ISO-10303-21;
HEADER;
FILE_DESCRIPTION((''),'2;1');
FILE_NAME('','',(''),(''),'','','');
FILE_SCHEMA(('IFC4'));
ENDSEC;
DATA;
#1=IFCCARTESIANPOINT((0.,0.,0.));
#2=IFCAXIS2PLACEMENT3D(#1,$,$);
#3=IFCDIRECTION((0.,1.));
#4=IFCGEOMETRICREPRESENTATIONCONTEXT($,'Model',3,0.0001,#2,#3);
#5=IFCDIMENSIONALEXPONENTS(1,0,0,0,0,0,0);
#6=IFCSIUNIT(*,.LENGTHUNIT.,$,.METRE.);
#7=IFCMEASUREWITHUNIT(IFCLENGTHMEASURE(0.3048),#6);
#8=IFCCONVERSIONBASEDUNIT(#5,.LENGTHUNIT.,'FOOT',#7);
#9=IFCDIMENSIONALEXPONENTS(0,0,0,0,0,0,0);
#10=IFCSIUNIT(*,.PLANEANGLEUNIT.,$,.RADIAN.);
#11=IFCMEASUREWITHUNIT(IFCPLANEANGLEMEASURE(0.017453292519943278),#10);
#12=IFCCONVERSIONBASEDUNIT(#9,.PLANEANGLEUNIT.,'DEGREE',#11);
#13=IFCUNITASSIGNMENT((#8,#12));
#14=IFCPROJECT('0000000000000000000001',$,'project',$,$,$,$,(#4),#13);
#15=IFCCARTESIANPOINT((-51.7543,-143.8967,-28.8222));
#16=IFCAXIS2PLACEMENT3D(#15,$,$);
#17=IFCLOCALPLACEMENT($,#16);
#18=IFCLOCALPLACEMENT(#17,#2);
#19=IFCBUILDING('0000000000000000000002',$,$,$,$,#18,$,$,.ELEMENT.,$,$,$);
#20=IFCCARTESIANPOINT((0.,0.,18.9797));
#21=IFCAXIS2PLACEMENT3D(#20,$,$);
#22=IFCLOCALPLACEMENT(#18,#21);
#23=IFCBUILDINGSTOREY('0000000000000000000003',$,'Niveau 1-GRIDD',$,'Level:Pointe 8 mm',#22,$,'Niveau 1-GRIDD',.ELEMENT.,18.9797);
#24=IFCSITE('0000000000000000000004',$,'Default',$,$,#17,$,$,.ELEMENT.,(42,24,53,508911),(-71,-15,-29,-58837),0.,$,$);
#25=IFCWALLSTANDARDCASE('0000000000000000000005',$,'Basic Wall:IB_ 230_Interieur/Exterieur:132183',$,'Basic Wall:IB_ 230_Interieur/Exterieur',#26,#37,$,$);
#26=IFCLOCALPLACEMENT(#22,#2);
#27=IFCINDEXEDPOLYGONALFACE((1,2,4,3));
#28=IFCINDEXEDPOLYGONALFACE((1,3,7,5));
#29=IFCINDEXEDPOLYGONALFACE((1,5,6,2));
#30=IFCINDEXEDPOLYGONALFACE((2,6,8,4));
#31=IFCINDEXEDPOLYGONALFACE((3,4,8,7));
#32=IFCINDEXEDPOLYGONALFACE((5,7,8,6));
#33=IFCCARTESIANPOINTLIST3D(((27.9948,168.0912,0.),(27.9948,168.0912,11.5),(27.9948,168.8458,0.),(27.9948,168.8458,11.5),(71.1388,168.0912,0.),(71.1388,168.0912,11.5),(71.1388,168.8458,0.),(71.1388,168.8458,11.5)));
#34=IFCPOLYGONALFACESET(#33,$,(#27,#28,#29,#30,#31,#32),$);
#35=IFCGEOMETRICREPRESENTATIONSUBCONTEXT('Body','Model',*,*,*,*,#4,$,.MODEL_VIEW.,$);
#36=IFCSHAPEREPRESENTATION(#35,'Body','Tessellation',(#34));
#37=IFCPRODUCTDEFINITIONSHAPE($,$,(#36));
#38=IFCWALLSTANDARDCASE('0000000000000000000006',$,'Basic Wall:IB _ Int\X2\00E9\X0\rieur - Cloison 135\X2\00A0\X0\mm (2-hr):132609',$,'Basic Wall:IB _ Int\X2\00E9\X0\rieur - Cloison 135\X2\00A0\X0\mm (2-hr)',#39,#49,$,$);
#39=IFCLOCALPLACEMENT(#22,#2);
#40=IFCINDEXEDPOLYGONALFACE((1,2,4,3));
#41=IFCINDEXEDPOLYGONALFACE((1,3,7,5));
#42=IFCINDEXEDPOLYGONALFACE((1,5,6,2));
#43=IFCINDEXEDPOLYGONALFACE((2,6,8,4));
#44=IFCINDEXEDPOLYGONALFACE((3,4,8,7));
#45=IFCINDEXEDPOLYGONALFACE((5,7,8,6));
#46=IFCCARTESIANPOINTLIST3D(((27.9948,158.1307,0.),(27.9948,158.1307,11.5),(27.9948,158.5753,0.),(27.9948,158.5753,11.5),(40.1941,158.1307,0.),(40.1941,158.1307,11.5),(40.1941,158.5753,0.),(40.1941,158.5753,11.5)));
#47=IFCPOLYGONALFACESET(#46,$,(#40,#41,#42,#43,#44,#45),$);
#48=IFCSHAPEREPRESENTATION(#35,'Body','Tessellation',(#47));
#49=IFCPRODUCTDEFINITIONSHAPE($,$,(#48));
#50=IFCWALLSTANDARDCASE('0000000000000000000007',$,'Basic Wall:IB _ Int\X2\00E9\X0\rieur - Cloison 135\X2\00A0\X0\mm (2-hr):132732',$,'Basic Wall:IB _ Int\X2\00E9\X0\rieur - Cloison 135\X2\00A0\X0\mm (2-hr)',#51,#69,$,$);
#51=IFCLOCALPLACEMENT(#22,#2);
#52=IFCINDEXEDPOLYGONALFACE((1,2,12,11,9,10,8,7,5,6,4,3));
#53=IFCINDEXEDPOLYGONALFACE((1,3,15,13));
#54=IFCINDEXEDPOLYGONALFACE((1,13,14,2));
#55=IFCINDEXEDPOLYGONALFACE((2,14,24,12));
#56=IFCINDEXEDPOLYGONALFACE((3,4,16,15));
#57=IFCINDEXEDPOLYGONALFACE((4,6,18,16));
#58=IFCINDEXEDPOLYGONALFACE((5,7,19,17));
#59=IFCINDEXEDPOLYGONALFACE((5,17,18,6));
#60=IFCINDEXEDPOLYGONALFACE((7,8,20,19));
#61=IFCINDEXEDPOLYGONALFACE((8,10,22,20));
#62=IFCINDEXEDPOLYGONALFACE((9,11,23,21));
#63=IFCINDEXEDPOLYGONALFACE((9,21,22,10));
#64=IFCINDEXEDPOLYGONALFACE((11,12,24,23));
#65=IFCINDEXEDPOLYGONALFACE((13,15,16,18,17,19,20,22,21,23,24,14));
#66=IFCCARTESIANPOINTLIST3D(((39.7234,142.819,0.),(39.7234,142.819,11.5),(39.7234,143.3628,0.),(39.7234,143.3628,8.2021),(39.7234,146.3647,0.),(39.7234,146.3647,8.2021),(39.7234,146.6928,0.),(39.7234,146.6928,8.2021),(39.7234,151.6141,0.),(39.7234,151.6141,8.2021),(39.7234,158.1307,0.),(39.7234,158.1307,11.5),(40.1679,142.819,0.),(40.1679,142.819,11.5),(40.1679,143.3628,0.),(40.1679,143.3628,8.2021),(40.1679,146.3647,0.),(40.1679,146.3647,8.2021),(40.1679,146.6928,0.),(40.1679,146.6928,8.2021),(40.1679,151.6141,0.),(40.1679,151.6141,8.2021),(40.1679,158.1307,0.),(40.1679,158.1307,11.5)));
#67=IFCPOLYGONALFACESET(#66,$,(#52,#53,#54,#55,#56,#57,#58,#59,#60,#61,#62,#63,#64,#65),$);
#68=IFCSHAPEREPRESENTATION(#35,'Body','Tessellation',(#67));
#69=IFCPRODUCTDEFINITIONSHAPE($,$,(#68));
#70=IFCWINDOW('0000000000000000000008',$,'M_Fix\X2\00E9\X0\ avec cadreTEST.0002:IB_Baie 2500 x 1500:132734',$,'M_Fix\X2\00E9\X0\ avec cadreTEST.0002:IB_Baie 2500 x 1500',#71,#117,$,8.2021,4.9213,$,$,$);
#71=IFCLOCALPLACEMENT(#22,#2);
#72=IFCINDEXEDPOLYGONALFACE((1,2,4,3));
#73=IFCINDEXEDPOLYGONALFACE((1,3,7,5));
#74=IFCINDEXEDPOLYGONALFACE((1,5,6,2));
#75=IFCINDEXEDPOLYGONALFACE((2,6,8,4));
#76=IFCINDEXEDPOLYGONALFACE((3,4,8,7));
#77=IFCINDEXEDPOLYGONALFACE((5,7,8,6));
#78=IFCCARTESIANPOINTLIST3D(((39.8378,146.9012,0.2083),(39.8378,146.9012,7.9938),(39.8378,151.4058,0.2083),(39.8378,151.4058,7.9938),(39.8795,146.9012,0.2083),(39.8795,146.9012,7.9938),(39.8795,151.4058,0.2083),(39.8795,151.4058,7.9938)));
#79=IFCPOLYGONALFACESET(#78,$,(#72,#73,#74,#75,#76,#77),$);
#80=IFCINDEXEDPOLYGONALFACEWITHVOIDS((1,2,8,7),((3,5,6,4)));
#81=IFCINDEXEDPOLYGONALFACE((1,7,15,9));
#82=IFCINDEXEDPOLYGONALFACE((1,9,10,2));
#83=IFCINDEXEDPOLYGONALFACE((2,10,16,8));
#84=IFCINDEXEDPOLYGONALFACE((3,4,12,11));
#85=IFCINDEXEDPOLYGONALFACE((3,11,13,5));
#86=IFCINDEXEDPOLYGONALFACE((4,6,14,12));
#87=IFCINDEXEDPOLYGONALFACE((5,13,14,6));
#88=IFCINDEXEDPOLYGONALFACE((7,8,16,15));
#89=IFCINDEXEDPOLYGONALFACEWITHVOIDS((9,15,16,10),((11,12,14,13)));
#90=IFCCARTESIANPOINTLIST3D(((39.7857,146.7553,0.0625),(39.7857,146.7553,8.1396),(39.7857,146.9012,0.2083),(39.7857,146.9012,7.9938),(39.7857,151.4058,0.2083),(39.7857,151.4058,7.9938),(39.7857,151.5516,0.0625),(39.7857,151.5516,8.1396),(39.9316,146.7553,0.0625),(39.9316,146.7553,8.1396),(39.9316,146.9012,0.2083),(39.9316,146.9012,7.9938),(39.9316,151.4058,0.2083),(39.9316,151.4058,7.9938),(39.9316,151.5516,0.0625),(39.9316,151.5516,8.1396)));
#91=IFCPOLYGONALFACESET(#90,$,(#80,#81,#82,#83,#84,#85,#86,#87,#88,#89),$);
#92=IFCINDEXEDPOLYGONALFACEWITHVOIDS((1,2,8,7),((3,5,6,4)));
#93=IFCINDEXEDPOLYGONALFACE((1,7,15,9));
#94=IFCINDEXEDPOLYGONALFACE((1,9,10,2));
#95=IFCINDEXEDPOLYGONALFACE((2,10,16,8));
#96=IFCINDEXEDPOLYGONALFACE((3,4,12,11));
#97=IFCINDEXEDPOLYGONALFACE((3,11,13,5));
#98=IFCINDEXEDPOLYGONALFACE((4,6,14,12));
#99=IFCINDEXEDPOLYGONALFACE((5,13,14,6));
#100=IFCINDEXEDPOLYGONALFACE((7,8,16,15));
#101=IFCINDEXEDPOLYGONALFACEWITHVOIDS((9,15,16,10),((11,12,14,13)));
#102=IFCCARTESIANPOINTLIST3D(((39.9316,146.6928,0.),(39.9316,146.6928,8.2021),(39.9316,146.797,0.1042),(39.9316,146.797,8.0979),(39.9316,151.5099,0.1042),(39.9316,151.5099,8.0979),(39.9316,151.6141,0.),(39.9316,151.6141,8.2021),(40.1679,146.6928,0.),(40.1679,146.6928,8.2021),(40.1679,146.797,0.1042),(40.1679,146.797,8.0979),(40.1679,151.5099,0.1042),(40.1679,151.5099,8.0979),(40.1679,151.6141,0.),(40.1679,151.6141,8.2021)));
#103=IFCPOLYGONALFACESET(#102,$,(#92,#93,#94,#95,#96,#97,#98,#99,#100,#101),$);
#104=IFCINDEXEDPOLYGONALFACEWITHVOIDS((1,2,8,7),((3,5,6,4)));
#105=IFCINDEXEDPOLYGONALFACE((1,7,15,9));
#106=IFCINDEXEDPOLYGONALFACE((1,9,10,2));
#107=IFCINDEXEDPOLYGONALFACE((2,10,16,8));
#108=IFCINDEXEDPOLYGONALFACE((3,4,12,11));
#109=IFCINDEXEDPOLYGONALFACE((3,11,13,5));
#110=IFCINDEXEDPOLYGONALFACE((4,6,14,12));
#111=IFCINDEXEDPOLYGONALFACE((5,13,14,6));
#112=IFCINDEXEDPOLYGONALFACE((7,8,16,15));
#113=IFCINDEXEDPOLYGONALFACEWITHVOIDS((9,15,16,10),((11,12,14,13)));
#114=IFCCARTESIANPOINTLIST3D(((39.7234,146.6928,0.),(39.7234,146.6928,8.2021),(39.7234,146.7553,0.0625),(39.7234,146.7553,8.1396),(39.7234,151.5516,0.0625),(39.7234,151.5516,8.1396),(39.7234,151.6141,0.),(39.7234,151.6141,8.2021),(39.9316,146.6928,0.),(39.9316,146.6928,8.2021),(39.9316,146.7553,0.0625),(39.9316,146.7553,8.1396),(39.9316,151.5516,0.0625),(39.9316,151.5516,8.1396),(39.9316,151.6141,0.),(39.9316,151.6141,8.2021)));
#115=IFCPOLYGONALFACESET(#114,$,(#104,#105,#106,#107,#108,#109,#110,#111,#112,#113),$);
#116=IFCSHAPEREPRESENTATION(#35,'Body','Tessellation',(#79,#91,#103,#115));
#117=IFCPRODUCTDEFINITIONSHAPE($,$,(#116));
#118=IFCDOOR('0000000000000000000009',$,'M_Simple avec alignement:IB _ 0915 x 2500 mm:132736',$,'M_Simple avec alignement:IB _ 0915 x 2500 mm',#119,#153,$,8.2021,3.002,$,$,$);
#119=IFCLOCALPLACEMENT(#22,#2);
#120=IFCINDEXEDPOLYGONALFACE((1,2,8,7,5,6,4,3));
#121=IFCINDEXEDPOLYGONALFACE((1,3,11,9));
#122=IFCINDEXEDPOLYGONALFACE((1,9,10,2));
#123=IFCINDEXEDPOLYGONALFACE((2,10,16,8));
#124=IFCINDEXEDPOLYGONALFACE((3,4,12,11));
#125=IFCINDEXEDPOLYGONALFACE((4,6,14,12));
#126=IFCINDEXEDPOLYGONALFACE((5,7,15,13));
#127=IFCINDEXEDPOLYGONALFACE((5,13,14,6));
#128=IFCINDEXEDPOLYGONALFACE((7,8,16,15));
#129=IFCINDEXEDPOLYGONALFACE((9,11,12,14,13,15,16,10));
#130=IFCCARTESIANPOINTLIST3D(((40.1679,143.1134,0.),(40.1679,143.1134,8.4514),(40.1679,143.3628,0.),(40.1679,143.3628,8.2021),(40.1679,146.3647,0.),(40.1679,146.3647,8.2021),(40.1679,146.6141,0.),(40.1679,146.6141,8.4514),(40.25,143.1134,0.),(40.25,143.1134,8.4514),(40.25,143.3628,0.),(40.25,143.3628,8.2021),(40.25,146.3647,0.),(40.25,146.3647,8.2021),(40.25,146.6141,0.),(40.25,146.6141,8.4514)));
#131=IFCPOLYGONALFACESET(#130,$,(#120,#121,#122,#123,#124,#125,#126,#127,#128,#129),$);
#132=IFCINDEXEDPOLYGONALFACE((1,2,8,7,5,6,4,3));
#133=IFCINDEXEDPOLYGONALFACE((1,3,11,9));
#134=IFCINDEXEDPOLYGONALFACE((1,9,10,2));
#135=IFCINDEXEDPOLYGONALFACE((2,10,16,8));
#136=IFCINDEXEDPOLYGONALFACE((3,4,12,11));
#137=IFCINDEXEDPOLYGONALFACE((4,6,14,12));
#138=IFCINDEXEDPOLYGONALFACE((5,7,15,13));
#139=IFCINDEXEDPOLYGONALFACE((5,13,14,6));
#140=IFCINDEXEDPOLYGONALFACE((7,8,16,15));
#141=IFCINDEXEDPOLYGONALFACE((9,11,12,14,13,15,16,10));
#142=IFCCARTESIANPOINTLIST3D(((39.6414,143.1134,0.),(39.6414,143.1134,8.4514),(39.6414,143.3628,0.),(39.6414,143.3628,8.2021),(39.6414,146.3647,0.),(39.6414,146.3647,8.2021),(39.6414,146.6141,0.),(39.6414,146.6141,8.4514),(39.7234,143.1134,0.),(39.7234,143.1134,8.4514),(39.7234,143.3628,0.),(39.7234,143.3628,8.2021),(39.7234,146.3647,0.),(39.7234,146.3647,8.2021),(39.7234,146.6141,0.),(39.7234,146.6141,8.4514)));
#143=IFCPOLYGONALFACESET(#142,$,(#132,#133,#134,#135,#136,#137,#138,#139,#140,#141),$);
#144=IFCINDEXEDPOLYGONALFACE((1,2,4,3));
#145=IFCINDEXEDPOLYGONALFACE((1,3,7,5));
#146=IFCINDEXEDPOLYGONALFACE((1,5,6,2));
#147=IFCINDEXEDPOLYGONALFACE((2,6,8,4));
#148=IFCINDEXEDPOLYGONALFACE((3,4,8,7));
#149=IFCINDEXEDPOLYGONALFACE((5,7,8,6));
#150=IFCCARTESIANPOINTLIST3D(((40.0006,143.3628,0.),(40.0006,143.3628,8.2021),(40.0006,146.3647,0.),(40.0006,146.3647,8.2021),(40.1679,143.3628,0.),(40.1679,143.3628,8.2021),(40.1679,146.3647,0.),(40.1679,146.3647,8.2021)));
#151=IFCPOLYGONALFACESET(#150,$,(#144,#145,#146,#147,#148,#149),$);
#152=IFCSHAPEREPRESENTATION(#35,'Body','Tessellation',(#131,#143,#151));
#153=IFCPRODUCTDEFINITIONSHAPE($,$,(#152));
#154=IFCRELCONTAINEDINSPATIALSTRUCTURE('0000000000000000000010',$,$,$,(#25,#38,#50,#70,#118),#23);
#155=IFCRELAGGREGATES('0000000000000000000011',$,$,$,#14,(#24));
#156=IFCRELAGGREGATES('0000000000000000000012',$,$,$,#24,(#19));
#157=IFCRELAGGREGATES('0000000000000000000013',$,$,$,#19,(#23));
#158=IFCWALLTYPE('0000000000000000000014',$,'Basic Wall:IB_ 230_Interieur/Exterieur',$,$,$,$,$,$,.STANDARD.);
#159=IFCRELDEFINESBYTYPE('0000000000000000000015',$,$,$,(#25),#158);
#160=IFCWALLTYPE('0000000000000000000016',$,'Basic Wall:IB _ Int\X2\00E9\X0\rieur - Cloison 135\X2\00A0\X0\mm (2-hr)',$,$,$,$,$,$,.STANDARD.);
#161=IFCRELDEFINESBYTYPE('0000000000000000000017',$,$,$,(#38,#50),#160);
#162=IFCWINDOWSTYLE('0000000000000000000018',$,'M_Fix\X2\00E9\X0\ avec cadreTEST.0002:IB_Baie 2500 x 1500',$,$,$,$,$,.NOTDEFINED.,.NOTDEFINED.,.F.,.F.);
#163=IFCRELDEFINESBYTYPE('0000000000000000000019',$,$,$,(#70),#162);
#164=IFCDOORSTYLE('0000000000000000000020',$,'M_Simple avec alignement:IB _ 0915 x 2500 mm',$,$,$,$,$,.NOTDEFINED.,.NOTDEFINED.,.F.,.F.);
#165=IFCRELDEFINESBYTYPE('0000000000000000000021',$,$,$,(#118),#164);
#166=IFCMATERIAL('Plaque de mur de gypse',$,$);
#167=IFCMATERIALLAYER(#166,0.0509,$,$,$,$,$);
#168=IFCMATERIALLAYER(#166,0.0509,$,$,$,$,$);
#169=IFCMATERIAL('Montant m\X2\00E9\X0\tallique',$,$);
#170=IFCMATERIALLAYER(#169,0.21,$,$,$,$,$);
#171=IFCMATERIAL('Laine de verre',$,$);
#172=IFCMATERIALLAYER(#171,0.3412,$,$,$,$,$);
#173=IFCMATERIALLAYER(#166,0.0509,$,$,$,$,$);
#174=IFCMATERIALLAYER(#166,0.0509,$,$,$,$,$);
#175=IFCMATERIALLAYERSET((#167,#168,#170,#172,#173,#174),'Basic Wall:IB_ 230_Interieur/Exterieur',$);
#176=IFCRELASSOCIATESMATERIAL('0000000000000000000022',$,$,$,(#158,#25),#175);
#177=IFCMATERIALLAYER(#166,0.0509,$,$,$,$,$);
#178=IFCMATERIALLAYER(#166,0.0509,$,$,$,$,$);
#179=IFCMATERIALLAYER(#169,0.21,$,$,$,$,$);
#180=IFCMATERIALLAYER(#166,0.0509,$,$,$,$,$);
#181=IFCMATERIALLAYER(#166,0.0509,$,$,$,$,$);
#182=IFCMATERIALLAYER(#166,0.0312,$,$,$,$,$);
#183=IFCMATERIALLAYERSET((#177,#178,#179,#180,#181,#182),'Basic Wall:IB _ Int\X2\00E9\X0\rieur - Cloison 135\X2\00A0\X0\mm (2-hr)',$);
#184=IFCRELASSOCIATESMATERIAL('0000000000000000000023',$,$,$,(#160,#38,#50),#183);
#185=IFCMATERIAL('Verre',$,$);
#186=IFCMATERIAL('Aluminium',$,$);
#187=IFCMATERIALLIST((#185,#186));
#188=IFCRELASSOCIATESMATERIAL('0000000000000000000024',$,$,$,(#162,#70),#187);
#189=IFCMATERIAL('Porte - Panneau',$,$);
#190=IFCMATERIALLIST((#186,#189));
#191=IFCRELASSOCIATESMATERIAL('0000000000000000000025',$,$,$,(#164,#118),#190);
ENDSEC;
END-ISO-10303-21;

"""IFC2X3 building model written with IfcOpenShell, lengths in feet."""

from ifc_helpers import new_model, entity, si_unit, converted_unit, direction, frame, frame_2d, origin, place, context, subcontext, project, spatial, polyline, rectangle, outline, extrude, source, transform, mapped, material, material_list, layer, layer_set, layer_usage, type_object, type_shapes, element, fill, save


model = new_model("IFC2X3")

# Units and contexts
model_context = context("Model", 3, precision=0.0001, world=origin(), true_north=direction((0.0, 1.0)))
body_context = subcontext(model_context, "Body", "Model", "MODEL_VIEW")
ifc_project = project(units=[converted_unit("LENGTHUNIT", "FOOT", entity("IfcLengthMeasure", 0.3048), si_unit("LENGTHUNIT", "METRE"), dimensions=[1, 0, 0, 0, 0, 0, 0]), converted_unit("PLANEANGLEUNIT", "DEGREE", entity("IfcPlaneAngleMeasure", 0.017453292519943278), si_unit("PLANEANGLEUNIT", "RADIAN"), dimensions=[0, 0, 0, 0, 0, 0, 0])], contexts=[model_context])

# Site, building, storey
site_placement = place(None, frame((-51.7543, -143.8967, -28.8222)))
site = spatial("IfcSite", under=ifc_project, at=site_placement, Name="Default", CompositionType="ELEMENT", RefLatitude=(42, 24, 53, 508911), RefLongitude=(-71, -15, -29, -58837), RefElevation=0.0)
building_placement = place(site_placement, origin())
building = spatial("IfcBuilding", under=site, at=building_placement, CompositionType="ELEMENT")
storey_placement = place(building_placement, frame((0.0, 0.0, 18.9797)))
storey = spatial("IfcBuildingStorey", under=building, at=storey_placement, Name="Niveau 1-GRIDD", ObjectType="Level:Pointe 8 mm", LongName="Niveau 1-GRIDD", CompositionType="ELEMENT", Elevation=18.9797)

# Walls
ifc_material_1 = material(Name="Plaque de mur de gypse")
ifc_layer_1 = layer(ifc_material_1, 0.0509)
ifc_layer_2 = layer(ifc_material_1, 0.0509)
ifc_material_2 = material(Name="Montant métallique")
ifc_layer_3 = layer(ifc_material_2, 0.21)
ifc_material_3 = material(Name="Laine de verre")
ifc_layer_4 = layer(ifc_material_3, 0.3412)
ifc_layer_5 = layer(ifc_material_1, 0.0509)
ifc_layer_6 = layer(ifc_material_1, 0.0509)
ifc_layer_set_1 = layer_set([ifc_layer_1, ifc_layer_2, ifc_layer_3, ifc_layer_4, ifc_layer_5, ifc_layer_6], Name="Basic Wall:IB_ 230_Interieur/Exterieur")
ifc_layer_usage_1 = layer_usage(ifc_layer_set_1, "AXIS2", "NEGATIVE", 0.3773)
wall_type_1 = type_object("IfcWallType", Name="Basic Wall:IB_ 230_Interieur/Exterieur", PredefinedType="STANDARD", material=ifc_layer_set_1)
wall_1_placement = place(storey_placement, frame((27.9948, 168.4685, 0.0)))
element("IfcWallStandardCase", 1, at=wall_1_placement, inside=storey, type_object=wall_type_1, material=ifc_layer_usage_1, Name="Basic Wall:IB_ 230_Interieur/Exterieur:132183", ObjectType="Basic Wall:IB_ 230_Interieur/Exterieur", context=body_context, shape_type="SweptSolid", body=[
    extrude(rectangle(XDim=43.144, YDim=0.7546, at=frame_2d((21.572, 0.0), x_axis=(-1.0, 0.0))), origin(), (0.0, 0.0, 1.0), 11.5),
])
ifc_layer_7 = layer(ifc_material_1, 0.0509)
ifc_layer_8 = layer(ifc_material_1, 0.0509)
ifc_layer_9 = layer(ifc_material_2, 0.21)
ifc_layer_10 = layer(ifc_material_1, 0.0509)
ifc_layer_11 = layer(ifc_material_1, 0.0509)
ifc_layer_12 = layer(ifc_material_1, 0.0312)
ifc_layer_set_2 = layer_set([ifc_layer_7, ifc_layer_8, ifc_layer_9, ifc_layer_10, ifc_layer_11, ifc_layer_12], Name="Basic Wall:IB _ Intérieur - Cloison 135 mm (2-hr)")
ifc_layer_usage_2 = layer_usage(ifc_layer_set_2, "AXIS2", "NEGATIVE", 0.2223)
wall_type_2 = type_object("IfcWallType", Name="Basic Wall:IB _ Intérieur - Cloison 135 mm (2-hr)", PredefinedType="STANDARD", material=ifc_layer_set_2)
wall_2_placement = place(storey_placement, frame((27.9948, 158.353, 0.0)))
element("IfcWallStandardCase", 2, at=wall_2_placement, inside=storey, type_object=wall_type_2, material=ifc_layer_usage_2, Name="Basic Wall:IB _ Intérieur - Cloison 135 mm (2-hr):132609", ObjectType="Basic Wall:IB _ Intérieur - Cloison 135 mm (2-hr)", context=body_context, shape_type="SweptSolid", body=[
    extrude(rectangle(XDim=12.1993, YDim=0.4446, at=frame_2d((6.0997, 0.0), x_axis=(-1.0, 0.0))), origin(), (0.0, 0.0, 1.0), 11.5),
])

# Wall, openings, window, door
ifc_layer_usage_3 = layer_usage(ifc_layer_set_2, "AXIS2", "NEGATIVE", 0.2223)
wall_3_placement = place(storey_placement, frame((39.9457, 158.1307, 0.0), z_axis=(0.0, 0.0, 1.0), x_axis=(0.0, -1.0, 0.0)))
wall_3 = element("IfcWallStandardCase", 3, at=wall_3_placement, inside=storey, type_object=wall_type_2, material=ifc_layer_usage_3, Name="Basic Wall:IB _ Intérieur - Cloison 135 mm (2-hr):132732", ObjectType="Basic Wall:IB _ Intérieur - Cloison 135 mm (2-hr)", context=body_context, shape_type="SweptSolid", body=[
    extrude(rectangle(XDim=15.3118, YDim=0.4446, at=frame_2d((7.6559, 0.0), x_axis=(1.0, 0.0))), origin(), (0.0, 0.0, 1.0), 11.5),
])
opening_1_placement = place(wall_3_placement, frame((11.4379, 0.2223, 0.0)))
opening_1 = element("IfcOpeningElement", 4, at=opening_1_placement, cuts=wall_3, ObjectType="Opening", context=body_context, shape_type="SweptSolid", body=[
    extrude(rectangle(XDim=8.2021, YDim=4.9213, at=frame_2d((4.101, 2.4606), x_axis=(-1.0, 0.0))), frame((0.0, 0.0, 0.0), z_axis=(0.0, -1.0, 0.0), x_axis=(0.0, 0.0, 1.0)), (0.0, 0.0, 1.0), 0.4446),
])
opening_2_placement = place(wall_3_placement, frame((11.766, -0.2223, 0.0)))
opening_2 = element("IfcOpeningElement", 5, at=opening_2_placement, cuts=wall_3, ObjectType="Opening", context=body_context, shape_type="SweptSolid", body=[
    extrude(rectangle(XDim=3.002, YDim=8.2021, at=frame_2d((4.101, 1.501), x_axis=(0.0, 1.0))), frame((0.0, 0.0, 0.0), z_axis=(0.0, 1.0, 0.0), x_axis=(0.0, 0.0, 1.0)), (0.0, 0.0, 1.0), 0.4446),
])
ifc_material_4 = material(Name="Verre")
ifc_material_5 = material(Name="Aluminium")
ifc_material_list_1 = material_list([ifc_material_4, ifc_material_5])
window_style = type_object("IfcWindowStyle", Name="M_Fixé avec cadreTEST.0002:IB_Baie 2500 x 1500", ConstructionType="NOTDEFINED", OperationType="NOTDEFINED", ParameterTakesPrecedence=False, Sizeable=False, material=ifc_material_list_1)
shared_shape_1 = source(origin(), body_context, "Body", "SweptSolid", [
    extrude(rectangle(XDim=0.0417, YDim=4.5046, at=frame_2d((0.0, 0.0), x_axis=(1.0, 0.0))), frame((2.4606, 0.3093, 0.2083), z_axis=(0.0, 0.0, 1.0), x_axis=(0.0, 1.0, 0.0)), (0.0, 0.0, 1.0), 7.7854),
    extrude(outline(polyline([(-2.3981, -4.0385), (2.3981, -4.0385), (2.3981, 4.0385), (-2.3981, 4.0385), (-2.3981, -4.0385)]), holes=[polyline([(-2.2523, -3.8927), (-2.2523, 3.8927), (2.2523, 3.8927), (2.2523, -3.8927), (-2.2523, -3.8927)])]), frame((2.4606, 0.2364, 4.101), z_axis=(0.0, 1.0, 0.0), x_axis=(1.0, 0.0, 0.0)), (0.0, 0.0, 1.0), 0.1458),
    extrude(outline(polyline([(-2.4606, -4.101), (2.4606, -4.101), (2.4606, 4.101), (-2.4606, 4.101), (-2.4606, -4.101)]), holes=[polyline([(-2.3565, -3.9969), (-2.3565, 3.9969), (2.3565, 3.9969), (2.3565, -3.9969), (-2.3565, -3.9969)])]), frame((2.4606, 0.0, 4.101), z_axis=(0.0, 1.0, 0.0), x_axis=(1.0, 0.0, 0.0)), (0.0, 0.0, 1.0), 0.2364),
    extrude(outline(polyline([(-4.101, -2.4606), (4.101, -2.4606), (4.101, 2.4606), (-4.101, 2.4606), (-4.101, -2.4606)]), holes=[polyline([(-4.0385, -2.3981), (-4.0385, 2.3981), (4.0385, 2.3981), (4.0385, -2.3981), (-4.0385, -2.3981)])]), frame((2.4606, 0.2364, 4.101), z_axis=(0.0, 1.0, 0.0), x_axis=(0.0, 0.0, -1.0)), (0.0, 0.0, 1.0), 0.2082),
])
type_shapes(window_style, [shared_shape_1])
window_placement = place(opening_1_placement, frame((0.0, 0.0, 0.0), z_axis=(0.0, 0.0, 1.0), x_axis=(-1.0, 0.0, 0.0)))
window = element("IfcWindow", 6, at=window_placement, inside=storey, type_object=window_style, material=ifc_material_list_1, Name="M_Fixé avec cadreTEST.0002:IB_Baie 2500 x 1500:132734", ObjectType="M_Fixé avec cadreTEST.0002:IB_Baie 2500 x 1500", OverallHeight=8.2021, OverallWidth=4.9213, context=body_context, shape_type="MappedRepresentation", body=[
    mapped(shared_shape_1, transform((0.0, 0.0, 0.0), scale=1.0)),
])
fill(opening_1, window)
ifc_material_6 = material(Name="Porte - Panneau")
ifc_material_list_2 = material_list([ifc_material_5, ifc_material_6])
door_style = type_object("IfcDoorStyle", Name="M_Simple avec alignement:IB _ 0915 x 2500 mm", ConstructionType="NOTDEFINED", OperationType="NOTDEFINED", ParameterTakesPrecedence=False, Sizeable=False, material=ifc_material_list_2)
shared_shape_2 = source(origin(), body_context, "Body", "SweptSolid", [
    extrude(outline(polyline([(-1.7503, -4.2881), (1.7503, -4.2881), (1.7503, 4.1634), (1.501, 4.1634), (1.501, -4.0387), (-1.501, -4.0387), (-1.501, 4.1634), (-1.7503, 4.1634), (-1.7503, -4.2881)])), frame((1.501, 0.4446, 4.1634), z_axis=(0.0, 1.0, 0.0), x_axis=(1.0, 0.0, 0.0)), (0.0, 0.0, 1.0), 0.082),
    extrude(outline(polyline([(-4.2881, -1.7503), (4.1634, -1.7503), (4.1634, -1.501), (-4.0387, -1.501), (-4.0387, 1.501), (4.1634, 1.501), (4.1634, 1.7503), (-4.2881, 1.7503), (-4.2881, -1.7503)])), frame((1.501, -0.082, 4.1634), z_axis=(0.0, 1.0, 0.0), x_axis=(0.0, 0.0, -1.0)), (0.0, 0.0, 1.0), 0.082),
    extrude(rectangle(XDim=0.1673, YDim=3.002, at=frame_2d((0.0, 0.0), x_axis=(1.0, 0.0))), frame((1.501, 0.3609, 0.0), z_axis=(0.0, 0.0, 1.0), x_axis=(0.0, 1.0, 0.0)), (0.0, 0.0, 1.0), 8.2021),
])
type_shapes(door_style, [shared_shape_2])
door_1_placement = place(opening_2_placement, origin())
door_1 = element("IfcDoor", 7, at=door_1_placement, inside=storey, type_object=door_style, material=ifc_material_list_2, Name="M_Simple avec alignement:IB _ 0915 x 2500 mm:132736", ObjectType="M_Simple avec alignement:IB _ 0915 x 2500 mm", OverallHeight=8.2021, OverallWidth=3.002, context=body_context, shape_type="MappedRepresentation", body=[
    mapped(shared_shape_2, transform((0.0, 0.0, 0.0), scale=1.0)),
])
fill(opening_2, door_1)

save(model, "model.ifc")
